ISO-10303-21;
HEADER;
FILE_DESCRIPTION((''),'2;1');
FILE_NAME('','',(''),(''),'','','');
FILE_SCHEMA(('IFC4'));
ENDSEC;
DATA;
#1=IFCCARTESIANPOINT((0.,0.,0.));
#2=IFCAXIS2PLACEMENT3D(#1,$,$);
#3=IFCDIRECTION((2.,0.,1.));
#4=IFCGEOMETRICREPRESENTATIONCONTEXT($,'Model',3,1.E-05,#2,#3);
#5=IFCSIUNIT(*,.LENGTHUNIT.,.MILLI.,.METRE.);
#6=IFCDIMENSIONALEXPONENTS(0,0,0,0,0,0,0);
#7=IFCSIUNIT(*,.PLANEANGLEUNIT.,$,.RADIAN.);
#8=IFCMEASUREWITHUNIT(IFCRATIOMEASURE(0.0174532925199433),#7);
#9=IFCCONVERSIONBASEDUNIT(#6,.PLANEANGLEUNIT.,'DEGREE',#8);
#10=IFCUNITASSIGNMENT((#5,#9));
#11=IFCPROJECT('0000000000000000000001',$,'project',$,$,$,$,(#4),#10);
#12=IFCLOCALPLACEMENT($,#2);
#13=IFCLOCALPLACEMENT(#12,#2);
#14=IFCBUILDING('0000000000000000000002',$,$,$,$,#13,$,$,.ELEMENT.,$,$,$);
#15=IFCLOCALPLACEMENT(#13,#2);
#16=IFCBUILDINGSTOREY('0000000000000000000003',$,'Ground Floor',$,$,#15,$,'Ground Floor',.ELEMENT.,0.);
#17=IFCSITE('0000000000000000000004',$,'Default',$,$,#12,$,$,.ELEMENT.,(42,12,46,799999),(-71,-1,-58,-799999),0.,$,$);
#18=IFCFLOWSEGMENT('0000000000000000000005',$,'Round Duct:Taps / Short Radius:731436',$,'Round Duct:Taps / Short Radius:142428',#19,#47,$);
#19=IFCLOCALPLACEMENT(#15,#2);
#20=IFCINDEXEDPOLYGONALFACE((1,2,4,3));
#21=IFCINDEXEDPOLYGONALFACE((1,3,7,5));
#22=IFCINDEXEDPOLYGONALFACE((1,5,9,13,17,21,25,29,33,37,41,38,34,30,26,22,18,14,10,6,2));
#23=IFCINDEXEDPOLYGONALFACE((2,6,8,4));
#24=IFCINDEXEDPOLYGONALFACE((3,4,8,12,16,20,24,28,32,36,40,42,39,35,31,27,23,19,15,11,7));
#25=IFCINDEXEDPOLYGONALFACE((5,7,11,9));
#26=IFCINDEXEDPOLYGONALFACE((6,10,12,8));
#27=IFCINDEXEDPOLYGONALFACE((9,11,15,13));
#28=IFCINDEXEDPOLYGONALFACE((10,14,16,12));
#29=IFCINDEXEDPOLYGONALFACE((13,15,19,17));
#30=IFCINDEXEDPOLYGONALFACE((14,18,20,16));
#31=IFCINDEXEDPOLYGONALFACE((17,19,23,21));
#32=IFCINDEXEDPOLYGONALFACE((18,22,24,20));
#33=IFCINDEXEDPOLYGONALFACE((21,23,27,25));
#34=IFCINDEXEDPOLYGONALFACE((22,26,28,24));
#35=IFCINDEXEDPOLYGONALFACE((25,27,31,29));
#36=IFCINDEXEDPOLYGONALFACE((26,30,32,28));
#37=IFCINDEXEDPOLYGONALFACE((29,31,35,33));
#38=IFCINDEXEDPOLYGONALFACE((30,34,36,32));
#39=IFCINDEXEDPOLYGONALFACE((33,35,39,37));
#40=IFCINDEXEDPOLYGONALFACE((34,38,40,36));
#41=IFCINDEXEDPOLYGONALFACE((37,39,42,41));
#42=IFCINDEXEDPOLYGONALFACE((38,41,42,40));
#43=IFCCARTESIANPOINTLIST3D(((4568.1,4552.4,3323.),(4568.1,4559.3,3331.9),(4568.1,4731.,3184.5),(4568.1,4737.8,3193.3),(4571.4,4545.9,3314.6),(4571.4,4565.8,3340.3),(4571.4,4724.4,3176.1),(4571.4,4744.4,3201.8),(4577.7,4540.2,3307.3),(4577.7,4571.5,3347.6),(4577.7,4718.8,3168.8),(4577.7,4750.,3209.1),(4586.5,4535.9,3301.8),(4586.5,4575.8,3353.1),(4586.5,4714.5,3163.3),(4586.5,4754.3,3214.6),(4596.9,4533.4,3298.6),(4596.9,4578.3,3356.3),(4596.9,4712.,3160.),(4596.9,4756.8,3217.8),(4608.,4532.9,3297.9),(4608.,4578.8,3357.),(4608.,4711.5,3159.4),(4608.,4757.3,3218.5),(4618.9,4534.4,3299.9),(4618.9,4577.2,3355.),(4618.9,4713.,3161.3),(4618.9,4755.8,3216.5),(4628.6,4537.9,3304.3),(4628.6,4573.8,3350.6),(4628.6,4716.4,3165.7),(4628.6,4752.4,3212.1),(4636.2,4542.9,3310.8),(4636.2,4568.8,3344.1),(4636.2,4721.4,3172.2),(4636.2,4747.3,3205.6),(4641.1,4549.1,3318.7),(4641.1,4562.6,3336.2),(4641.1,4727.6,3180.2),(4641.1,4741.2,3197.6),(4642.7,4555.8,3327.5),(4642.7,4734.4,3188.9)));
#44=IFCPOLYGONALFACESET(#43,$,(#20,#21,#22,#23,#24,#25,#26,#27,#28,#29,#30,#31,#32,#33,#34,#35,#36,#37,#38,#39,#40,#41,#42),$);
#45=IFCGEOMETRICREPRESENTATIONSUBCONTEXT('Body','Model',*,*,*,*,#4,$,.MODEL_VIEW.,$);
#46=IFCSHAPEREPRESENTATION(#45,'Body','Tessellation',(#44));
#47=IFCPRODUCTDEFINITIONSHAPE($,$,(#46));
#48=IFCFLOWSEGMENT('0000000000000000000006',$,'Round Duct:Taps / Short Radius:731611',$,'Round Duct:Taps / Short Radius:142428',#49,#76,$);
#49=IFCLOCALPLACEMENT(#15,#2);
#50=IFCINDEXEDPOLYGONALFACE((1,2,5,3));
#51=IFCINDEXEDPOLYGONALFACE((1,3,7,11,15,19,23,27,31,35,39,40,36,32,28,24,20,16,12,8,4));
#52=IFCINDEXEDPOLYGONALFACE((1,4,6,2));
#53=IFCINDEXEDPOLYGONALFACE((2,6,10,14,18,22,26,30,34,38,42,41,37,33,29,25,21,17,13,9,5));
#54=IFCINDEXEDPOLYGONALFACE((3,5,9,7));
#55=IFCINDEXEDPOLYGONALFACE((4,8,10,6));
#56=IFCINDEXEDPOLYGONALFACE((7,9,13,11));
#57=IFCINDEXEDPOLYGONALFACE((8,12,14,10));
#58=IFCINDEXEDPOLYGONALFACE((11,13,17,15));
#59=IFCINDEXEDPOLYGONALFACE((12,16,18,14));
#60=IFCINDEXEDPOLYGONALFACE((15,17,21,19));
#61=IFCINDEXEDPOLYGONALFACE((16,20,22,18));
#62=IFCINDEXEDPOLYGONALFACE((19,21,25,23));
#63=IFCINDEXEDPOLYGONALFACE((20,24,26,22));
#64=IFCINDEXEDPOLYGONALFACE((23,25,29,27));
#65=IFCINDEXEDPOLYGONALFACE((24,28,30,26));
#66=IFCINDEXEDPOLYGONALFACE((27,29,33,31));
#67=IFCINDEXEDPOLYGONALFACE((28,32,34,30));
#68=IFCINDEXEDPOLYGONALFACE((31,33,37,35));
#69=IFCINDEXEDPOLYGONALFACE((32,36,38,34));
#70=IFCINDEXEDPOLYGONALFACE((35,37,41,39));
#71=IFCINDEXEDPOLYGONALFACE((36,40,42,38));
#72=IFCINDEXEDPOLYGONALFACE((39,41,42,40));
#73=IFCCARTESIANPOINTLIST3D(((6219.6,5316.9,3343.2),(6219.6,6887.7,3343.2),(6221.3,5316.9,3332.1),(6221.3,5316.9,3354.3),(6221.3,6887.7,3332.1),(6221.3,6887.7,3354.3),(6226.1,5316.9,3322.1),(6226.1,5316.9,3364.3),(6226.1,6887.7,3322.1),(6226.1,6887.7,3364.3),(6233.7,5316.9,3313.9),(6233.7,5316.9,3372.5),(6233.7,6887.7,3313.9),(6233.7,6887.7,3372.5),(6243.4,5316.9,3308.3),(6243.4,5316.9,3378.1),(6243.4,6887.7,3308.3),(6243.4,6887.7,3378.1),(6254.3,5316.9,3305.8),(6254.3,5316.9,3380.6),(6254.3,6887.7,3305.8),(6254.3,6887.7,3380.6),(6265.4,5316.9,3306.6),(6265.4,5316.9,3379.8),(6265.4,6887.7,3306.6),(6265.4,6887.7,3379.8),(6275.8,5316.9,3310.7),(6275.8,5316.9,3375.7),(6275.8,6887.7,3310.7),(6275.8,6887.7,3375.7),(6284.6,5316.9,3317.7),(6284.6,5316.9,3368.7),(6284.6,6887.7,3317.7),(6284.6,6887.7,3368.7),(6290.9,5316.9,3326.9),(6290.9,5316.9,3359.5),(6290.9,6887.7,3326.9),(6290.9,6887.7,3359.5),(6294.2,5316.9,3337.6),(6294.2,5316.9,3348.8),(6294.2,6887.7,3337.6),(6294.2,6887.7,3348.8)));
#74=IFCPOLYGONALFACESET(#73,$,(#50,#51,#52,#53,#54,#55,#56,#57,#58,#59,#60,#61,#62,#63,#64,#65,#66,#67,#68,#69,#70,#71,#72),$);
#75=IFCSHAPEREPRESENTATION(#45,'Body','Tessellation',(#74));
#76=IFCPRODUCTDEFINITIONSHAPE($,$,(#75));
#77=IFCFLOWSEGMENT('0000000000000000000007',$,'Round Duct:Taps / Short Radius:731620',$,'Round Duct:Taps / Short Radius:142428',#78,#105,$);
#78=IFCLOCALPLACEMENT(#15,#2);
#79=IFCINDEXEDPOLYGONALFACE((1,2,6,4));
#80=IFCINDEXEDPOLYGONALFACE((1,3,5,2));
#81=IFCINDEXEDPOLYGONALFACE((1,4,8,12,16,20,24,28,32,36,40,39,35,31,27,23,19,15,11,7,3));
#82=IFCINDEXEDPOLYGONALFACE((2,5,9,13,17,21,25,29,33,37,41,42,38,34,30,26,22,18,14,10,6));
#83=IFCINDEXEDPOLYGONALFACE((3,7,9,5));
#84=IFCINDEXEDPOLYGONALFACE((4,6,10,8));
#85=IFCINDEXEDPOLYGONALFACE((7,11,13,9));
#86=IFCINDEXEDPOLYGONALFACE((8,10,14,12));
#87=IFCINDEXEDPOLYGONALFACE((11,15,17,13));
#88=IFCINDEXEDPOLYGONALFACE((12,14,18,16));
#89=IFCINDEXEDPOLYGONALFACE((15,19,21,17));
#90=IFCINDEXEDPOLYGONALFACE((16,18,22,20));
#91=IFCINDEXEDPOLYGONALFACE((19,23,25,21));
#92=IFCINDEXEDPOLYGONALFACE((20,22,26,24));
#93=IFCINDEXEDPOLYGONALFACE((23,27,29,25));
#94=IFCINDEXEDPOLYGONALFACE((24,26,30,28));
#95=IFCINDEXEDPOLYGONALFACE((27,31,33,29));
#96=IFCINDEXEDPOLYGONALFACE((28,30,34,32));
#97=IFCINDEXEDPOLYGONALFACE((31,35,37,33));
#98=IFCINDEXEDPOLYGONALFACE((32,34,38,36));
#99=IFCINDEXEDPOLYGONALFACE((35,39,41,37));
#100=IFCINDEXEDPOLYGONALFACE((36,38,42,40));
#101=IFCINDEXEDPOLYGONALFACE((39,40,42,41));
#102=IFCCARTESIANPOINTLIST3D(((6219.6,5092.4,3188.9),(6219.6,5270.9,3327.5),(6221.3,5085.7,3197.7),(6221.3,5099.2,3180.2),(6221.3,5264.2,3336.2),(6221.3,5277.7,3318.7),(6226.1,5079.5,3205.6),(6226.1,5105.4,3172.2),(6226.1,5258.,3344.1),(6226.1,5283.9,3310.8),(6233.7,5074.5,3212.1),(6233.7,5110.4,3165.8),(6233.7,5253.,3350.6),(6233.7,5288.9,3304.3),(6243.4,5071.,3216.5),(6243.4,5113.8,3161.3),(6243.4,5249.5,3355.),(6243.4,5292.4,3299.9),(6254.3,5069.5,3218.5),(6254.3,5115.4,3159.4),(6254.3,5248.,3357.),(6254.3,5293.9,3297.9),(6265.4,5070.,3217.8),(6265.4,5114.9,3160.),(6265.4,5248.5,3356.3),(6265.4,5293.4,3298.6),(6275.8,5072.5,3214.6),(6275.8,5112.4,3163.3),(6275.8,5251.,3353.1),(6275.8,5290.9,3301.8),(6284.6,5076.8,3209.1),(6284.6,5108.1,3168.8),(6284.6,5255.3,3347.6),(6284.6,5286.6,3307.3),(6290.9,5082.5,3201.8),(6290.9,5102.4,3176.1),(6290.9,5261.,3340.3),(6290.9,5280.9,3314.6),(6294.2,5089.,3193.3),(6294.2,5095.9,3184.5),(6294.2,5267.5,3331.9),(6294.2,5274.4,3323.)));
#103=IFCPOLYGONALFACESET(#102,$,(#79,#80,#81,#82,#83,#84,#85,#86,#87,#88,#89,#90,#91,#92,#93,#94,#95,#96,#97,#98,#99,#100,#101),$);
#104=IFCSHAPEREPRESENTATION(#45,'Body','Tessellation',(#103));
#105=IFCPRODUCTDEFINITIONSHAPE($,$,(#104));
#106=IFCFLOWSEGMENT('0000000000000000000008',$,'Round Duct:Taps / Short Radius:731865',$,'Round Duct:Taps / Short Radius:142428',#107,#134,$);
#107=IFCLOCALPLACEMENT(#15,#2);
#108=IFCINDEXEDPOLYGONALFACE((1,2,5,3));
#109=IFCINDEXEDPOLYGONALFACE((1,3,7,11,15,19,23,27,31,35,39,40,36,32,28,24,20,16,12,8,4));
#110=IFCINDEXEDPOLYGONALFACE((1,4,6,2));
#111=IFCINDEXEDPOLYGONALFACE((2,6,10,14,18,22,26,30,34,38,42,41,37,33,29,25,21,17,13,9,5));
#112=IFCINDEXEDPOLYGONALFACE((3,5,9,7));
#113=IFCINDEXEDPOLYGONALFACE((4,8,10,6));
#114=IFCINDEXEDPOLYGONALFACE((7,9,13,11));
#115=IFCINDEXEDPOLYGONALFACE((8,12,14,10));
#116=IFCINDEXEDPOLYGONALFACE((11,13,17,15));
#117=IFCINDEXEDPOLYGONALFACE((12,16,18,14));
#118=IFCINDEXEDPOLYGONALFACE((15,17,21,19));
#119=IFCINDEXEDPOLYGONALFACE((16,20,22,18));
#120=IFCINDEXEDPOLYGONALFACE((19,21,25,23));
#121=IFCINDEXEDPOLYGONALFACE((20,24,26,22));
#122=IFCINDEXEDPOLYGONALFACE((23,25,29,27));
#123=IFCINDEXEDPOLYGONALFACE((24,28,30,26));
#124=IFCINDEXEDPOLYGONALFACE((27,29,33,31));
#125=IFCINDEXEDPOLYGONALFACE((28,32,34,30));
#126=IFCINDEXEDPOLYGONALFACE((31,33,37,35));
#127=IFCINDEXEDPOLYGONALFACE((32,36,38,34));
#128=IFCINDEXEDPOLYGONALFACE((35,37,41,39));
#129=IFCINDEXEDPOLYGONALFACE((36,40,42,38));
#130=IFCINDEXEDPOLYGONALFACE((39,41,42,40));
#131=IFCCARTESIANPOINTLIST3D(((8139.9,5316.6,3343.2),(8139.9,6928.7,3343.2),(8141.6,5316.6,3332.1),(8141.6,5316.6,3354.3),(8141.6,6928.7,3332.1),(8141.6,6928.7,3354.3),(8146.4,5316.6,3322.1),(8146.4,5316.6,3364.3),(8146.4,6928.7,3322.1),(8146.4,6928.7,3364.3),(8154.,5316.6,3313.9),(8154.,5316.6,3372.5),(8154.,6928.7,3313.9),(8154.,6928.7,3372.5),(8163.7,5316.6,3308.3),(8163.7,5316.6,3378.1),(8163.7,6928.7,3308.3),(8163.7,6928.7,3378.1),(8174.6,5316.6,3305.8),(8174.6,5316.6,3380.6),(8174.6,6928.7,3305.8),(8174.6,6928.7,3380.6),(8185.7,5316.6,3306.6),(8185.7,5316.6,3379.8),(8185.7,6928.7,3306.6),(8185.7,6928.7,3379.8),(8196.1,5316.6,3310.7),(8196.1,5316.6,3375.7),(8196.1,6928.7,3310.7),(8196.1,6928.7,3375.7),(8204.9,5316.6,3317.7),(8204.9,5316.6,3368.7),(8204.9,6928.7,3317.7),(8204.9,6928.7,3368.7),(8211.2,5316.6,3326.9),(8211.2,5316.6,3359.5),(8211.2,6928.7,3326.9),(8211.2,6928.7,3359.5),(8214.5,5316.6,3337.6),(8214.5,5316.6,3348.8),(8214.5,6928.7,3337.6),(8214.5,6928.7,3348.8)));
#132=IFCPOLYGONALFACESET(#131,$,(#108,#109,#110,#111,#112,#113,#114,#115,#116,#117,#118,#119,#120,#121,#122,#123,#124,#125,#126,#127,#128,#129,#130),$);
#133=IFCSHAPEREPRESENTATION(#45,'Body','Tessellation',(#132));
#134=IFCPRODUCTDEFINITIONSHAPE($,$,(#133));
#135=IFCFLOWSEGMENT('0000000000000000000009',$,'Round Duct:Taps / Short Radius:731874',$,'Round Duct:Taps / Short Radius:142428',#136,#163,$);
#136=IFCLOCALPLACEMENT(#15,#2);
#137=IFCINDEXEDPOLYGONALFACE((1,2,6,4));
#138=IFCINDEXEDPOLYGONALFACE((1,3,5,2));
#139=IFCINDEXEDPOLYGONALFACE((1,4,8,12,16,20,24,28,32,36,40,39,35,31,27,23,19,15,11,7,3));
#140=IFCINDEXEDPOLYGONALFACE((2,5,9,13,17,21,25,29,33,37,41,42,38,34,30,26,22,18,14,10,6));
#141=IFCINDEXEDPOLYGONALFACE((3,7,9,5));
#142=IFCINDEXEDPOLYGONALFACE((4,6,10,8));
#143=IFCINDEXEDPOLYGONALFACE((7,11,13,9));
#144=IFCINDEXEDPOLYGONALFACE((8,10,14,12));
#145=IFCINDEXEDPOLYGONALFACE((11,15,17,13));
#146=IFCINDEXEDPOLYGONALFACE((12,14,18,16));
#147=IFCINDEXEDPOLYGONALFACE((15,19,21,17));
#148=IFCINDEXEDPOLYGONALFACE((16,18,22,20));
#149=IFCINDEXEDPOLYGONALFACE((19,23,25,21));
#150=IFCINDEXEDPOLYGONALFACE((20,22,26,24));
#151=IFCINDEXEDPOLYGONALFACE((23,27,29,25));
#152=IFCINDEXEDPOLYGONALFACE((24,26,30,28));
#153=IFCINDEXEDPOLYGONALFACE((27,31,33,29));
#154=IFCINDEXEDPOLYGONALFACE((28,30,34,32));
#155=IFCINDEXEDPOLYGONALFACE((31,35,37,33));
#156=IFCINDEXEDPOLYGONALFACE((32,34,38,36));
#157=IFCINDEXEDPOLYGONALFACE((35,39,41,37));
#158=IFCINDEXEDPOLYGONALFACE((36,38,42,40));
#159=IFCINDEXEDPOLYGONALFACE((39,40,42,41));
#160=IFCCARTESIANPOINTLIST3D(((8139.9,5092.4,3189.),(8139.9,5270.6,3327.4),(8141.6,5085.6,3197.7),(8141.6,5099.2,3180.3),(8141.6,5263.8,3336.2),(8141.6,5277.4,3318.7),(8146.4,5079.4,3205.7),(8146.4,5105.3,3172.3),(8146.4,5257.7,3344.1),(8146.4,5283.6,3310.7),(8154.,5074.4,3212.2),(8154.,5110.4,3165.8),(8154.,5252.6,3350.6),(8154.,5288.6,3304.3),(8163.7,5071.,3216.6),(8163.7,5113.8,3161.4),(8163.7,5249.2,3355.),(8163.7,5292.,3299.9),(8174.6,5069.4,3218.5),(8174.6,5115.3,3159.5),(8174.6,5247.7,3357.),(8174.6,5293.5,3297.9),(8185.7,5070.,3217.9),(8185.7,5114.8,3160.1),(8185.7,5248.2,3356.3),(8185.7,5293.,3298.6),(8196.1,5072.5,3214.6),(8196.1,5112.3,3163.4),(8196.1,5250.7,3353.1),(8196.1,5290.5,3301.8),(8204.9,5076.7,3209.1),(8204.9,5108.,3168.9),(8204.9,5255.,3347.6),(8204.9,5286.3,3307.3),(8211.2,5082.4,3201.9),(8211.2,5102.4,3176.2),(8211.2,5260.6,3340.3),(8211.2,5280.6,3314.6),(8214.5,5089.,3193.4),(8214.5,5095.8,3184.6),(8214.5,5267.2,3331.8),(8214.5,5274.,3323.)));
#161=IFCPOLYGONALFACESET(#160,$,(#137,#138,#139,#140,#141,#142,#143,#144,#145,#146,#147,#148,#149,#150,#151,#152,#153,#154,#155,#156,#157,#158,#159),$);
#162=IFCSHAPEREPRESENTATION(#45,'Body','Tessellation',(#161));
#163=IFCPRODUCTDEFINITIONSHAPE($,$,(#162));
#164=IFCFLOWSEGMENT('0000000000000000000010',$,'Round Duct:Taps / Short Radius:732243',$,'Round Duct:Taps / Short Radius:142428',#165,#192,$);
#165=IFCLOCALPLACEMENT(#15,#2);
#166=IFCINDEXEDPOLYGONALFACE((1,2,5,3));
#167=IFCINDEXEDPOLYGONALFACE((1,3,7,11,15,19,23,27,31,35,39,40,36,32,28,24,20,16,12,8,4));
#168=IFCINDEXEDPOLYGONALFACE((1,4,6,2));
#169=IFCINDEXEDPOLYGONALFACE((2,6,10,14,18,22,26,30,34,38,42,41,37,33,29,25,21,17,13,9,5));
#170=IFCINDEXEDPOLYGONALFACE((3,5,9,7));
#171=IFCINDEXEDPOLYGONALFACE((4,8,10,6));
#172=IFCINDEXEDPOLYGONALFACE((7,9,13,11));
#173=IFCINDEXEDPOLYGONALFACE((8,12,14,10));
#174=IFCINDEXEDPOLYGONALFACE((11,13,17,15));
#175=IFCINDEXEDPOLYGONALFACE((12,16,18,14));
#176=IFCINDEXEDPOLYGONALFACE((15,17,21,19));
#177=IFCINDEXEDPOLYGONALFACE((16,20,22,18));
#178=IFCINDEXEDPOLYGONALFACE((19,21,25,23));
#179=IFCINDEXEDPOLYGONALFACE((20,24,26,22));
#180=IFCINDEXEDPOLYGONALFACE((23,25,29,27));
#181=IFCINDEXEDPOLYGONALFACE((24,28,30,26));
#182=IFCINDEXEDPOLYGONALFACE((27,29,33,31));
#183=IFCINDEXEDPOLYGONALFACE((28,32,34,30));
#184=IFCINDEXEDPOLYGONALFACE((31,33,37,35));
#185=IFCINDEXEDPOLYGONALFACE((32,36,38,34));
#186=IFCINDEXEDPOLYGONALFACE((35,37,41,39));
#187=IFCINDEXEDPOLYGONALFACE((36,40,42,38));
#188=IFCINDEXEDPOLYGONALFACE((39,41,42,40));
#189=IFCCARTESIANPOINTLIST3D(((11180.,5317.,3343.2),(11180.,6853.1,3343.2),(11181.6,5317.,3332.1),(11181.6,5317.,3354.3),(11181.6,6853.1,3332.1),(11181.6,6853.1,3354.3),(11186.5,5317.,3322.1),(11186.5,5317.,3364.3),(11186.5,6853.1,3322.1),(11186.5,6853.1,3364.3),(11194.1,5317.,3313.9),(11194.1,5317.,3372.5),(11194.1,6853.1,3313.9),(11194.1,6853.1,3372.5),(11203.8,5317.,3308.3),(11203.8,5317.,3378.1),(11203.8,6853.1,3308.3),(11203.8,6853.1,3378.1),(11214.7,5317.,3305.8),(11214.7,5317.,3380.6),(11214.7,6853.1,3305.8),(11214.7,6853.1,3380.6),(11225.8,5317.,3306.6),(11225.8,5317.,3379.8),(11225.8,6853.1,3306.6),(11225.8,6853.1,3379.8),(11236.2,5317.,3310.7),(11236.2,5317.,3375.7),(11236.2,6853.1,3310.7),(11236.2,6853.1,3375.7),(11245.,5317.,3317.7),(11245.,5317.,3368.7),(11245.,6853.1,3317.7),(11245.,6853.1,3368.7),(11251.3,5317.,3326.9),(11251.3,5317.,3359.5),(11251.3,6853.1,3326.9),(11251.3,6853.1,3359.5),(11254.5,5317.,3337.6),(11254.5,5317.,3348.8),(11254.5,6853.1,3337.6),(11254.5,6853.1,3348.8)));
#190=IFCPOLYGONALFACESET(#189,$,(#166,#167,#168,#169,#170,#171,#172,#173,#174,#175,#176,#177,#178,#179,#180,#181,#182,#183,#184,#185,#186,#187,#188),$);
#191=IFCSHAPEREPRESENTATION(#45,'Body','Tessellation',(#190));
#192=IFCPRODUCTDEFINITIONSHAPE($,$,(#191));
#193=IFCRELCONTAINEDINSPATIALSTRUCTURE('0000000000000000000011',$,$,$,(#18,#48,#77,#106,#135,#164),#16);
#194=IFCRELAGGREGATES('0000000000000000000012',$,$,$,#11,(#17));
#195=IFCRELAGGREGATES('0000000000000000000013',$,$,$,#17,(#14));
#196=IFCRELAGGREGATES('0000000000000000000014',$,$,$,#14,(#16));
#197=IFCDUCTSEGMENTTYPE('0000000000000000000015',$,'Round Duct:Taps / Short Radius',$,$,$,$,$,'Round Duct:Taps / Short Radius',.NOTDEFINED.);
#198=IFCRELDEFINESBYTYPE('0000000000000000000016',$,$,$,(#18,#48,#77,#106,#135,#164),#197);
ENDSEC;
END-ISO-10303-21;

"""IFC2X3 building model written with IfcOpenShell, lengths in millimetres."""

from ifc_helpers import new_model, entity, si_unit, converted_unit, direction, frame, frame_2d, origin, place, context, subcontext, project, spatial, circle, extrude, type_object, element, save


model = new_model("IFC2X3")

# Units and contexts
model_context = context("Model", 3, precision=1e-05, world=origin(), true_north=direction((2.0, 0.0, 1.0)))
body_context = subcontext(model_context, "Body", "Model", "MODEL_VIEW")
ifc_project = project(units=[si_unit("LENGTHUNIT", "METRE", prefix="MILLI"), converted_unit("PLANEANGLEUNIT", "DEGREE", entity("IfcRatioMeasure", 0.0174532925199433), si_unit("PLANEANGLEUNIT", "RADIAN"), dimensions=[0, 0, 0, 0, 0, 0, 0])], contexts=[model_context])

# Site, building, storey
site_placement = place(None, origin())
site = spatial("IfcSite", under=ifc_project, at=site_placement, Name="Default", CompositionType="ELEMENT", RefLatitude=(42, 12, 46, 799999), RefLongitude=(-71, -1, -58, -799999), RefElevation=0.0)
building_placement = place(site_placement, origin())
building = spatial("IfcBuilding", under=site, at=building_placement, CompositionType="ELEMENT")
storey_placement = place(building_placement, origin())
storey = spatial("IfcBuildingStorey", under=building, at=storey_placement, Name="Ground Floor", LongName="Ground Floor", CompositionType="ELEMENT", Elevation=0.0)

# Flow segments
duct_segment_type_1 = type_object("IfcDuctSegmentType", Name="Round Duct:Taps / Short Radius", ElementType="Round Duct:Taps / Short Radius", PredefinedType="NOTDEFINED")
flow_segment_1_placement = place(storey_placement, origin())
element("IfcFlowSegment", 1, at=flow_segment_1_placement, inside=storey, type_object=duct_segment_type_1, Name="Round Duct:Taps / Short Radius:731436", ObjectType="Round Duct:Taps / Short Radius:142428", context=body_context, shape_type="SweptSolid", body=[
    extrude(circle(Radius=37.5, at=frame_2d((0.0, 0.0), x_axis=(1.0, 0.0))), frame((4605.2, 4555.8, 3327.5), z_axis=(0.0, 0.790062, -0.613027), x_axis=(1.0, 0.0, 0.0)), (0.0, 0.0, 1.0), 226.0),
])
flow_segment_2_placement = place(storey_placement, origin())
element("IfcFlowSegment", 2, at=flow_segment_2_placement, inside=storey, type_object=duct_segment_type_1, Name="Round Duct:Taps / Short Radius:731611", ObjectType="Round Duct:Taps / Short Radius:142428", context=body_context, shape_type="SweptSolid", body=[
    extrude(circle(Radius=37.5, at=frame_2d((0.0, 0.0), x_axis=(1.0, 0.0))), frame((6257.1, 5316.9, 3343.2), z_axis=(0.0, 1.0, 0.0), x_axis=(-1.0, 0.0, 0.0)), (0.0, 0.0, 1.0), 1570.7),
])
flow_segment_3_placement = place(storey_placement, origin())
element("IfcFlowSegment", 3, at=flow_segment_3_placement, inside=storey, type_object=duct_segment_type_1, Name="Round Duct:Taps / Short Radius:731620", ObjectType="Round Duct:Taps / Short Radius:142428", context=body_context, shape_type="SweptSolid", body=[
    extrude(circle(Radius=37.5, at=frame_2d((0.0, 0.0), x_axis=(1.0, 0.0))), frame((6257.1, 5092.4, 3188.9), z_axis=(0.0, 0.790021, 0.61308), x_axis=(-1.0, 0.0, 0.0)), (0.0, 0.0, 1.0), 226.0),
])
flow_segment_4_placement = place(storey_placement, origin())
element("IfcFlowSegment", 4, at=flow_segment_4_placement, inside=storey, type_object=duct_segment_type_1, Name="Round Duct:Taps / Short Radius:731865", ObjectType="Round Duct:Taps / Short Radius:142428", context=body_context, shape_type="SweptSolid", body=[
    extrude(circle(Radius=37.5, at=frame_2d((0.0, 0.0), x_axis=(1.0, 0.0))), frame((8177.4, 5316.6, 3343.2), z_axis=(0.0, 1.0, 0.0), x_axis=(-1.0, 0.0, 0.0)), (0.0, 0.0, 1.0), 1612.1),
])
flow_segment_5_placement = place(storey_placement, origin())
element("IfcFlowSegment", 5, at=flow_segment_5_placement, inside=storey, type_object=duct_segment_type_1, Name="Round Duct:Taps / Short Radius:731874", ObjectType="Round Duct:Taps / Short Radius:142428", context=body_context, shape_type="SweptSolid", body=[
    extrude(circle(Radius=37.5, at=frame_2d((0.0, 0.0), x_axis=(1.0, 0.0))), frame((8177.4, 5092.4, 3189.0), z_axis=(0.0, 0.789759, 0.613417), x_axis=(-1.0, 0.0, 0.0)), (0.0, 0.0, 1.0), 225.7),
])
flow_segment_6_placement = place(storey_placement, origin())
element("IfcFlowSegment", 6, at=flow_segment_6_placement, inside=storey, type_object=duct_segment_type_1, Name="Round Duct:Taps / Short Radius:732243", ObjectType="Round Duct:Taps / Short Radius:142428", context=body_context, shape_type="SweptSolid", body=[
    extrude(circle(Radius=37.5, at=frame_2d((0.0, 0.0), x_axis=(1.0, 0.0))), frame((11217.5, 5317.0, 3343.2), z_axis=(0.0, 1.0, 0.0), x_axis=(-1.0, 0.0, 0.0)), (0.0, 0.0, 1.0), 1536.1),
])

save(model, "model.ifc")
